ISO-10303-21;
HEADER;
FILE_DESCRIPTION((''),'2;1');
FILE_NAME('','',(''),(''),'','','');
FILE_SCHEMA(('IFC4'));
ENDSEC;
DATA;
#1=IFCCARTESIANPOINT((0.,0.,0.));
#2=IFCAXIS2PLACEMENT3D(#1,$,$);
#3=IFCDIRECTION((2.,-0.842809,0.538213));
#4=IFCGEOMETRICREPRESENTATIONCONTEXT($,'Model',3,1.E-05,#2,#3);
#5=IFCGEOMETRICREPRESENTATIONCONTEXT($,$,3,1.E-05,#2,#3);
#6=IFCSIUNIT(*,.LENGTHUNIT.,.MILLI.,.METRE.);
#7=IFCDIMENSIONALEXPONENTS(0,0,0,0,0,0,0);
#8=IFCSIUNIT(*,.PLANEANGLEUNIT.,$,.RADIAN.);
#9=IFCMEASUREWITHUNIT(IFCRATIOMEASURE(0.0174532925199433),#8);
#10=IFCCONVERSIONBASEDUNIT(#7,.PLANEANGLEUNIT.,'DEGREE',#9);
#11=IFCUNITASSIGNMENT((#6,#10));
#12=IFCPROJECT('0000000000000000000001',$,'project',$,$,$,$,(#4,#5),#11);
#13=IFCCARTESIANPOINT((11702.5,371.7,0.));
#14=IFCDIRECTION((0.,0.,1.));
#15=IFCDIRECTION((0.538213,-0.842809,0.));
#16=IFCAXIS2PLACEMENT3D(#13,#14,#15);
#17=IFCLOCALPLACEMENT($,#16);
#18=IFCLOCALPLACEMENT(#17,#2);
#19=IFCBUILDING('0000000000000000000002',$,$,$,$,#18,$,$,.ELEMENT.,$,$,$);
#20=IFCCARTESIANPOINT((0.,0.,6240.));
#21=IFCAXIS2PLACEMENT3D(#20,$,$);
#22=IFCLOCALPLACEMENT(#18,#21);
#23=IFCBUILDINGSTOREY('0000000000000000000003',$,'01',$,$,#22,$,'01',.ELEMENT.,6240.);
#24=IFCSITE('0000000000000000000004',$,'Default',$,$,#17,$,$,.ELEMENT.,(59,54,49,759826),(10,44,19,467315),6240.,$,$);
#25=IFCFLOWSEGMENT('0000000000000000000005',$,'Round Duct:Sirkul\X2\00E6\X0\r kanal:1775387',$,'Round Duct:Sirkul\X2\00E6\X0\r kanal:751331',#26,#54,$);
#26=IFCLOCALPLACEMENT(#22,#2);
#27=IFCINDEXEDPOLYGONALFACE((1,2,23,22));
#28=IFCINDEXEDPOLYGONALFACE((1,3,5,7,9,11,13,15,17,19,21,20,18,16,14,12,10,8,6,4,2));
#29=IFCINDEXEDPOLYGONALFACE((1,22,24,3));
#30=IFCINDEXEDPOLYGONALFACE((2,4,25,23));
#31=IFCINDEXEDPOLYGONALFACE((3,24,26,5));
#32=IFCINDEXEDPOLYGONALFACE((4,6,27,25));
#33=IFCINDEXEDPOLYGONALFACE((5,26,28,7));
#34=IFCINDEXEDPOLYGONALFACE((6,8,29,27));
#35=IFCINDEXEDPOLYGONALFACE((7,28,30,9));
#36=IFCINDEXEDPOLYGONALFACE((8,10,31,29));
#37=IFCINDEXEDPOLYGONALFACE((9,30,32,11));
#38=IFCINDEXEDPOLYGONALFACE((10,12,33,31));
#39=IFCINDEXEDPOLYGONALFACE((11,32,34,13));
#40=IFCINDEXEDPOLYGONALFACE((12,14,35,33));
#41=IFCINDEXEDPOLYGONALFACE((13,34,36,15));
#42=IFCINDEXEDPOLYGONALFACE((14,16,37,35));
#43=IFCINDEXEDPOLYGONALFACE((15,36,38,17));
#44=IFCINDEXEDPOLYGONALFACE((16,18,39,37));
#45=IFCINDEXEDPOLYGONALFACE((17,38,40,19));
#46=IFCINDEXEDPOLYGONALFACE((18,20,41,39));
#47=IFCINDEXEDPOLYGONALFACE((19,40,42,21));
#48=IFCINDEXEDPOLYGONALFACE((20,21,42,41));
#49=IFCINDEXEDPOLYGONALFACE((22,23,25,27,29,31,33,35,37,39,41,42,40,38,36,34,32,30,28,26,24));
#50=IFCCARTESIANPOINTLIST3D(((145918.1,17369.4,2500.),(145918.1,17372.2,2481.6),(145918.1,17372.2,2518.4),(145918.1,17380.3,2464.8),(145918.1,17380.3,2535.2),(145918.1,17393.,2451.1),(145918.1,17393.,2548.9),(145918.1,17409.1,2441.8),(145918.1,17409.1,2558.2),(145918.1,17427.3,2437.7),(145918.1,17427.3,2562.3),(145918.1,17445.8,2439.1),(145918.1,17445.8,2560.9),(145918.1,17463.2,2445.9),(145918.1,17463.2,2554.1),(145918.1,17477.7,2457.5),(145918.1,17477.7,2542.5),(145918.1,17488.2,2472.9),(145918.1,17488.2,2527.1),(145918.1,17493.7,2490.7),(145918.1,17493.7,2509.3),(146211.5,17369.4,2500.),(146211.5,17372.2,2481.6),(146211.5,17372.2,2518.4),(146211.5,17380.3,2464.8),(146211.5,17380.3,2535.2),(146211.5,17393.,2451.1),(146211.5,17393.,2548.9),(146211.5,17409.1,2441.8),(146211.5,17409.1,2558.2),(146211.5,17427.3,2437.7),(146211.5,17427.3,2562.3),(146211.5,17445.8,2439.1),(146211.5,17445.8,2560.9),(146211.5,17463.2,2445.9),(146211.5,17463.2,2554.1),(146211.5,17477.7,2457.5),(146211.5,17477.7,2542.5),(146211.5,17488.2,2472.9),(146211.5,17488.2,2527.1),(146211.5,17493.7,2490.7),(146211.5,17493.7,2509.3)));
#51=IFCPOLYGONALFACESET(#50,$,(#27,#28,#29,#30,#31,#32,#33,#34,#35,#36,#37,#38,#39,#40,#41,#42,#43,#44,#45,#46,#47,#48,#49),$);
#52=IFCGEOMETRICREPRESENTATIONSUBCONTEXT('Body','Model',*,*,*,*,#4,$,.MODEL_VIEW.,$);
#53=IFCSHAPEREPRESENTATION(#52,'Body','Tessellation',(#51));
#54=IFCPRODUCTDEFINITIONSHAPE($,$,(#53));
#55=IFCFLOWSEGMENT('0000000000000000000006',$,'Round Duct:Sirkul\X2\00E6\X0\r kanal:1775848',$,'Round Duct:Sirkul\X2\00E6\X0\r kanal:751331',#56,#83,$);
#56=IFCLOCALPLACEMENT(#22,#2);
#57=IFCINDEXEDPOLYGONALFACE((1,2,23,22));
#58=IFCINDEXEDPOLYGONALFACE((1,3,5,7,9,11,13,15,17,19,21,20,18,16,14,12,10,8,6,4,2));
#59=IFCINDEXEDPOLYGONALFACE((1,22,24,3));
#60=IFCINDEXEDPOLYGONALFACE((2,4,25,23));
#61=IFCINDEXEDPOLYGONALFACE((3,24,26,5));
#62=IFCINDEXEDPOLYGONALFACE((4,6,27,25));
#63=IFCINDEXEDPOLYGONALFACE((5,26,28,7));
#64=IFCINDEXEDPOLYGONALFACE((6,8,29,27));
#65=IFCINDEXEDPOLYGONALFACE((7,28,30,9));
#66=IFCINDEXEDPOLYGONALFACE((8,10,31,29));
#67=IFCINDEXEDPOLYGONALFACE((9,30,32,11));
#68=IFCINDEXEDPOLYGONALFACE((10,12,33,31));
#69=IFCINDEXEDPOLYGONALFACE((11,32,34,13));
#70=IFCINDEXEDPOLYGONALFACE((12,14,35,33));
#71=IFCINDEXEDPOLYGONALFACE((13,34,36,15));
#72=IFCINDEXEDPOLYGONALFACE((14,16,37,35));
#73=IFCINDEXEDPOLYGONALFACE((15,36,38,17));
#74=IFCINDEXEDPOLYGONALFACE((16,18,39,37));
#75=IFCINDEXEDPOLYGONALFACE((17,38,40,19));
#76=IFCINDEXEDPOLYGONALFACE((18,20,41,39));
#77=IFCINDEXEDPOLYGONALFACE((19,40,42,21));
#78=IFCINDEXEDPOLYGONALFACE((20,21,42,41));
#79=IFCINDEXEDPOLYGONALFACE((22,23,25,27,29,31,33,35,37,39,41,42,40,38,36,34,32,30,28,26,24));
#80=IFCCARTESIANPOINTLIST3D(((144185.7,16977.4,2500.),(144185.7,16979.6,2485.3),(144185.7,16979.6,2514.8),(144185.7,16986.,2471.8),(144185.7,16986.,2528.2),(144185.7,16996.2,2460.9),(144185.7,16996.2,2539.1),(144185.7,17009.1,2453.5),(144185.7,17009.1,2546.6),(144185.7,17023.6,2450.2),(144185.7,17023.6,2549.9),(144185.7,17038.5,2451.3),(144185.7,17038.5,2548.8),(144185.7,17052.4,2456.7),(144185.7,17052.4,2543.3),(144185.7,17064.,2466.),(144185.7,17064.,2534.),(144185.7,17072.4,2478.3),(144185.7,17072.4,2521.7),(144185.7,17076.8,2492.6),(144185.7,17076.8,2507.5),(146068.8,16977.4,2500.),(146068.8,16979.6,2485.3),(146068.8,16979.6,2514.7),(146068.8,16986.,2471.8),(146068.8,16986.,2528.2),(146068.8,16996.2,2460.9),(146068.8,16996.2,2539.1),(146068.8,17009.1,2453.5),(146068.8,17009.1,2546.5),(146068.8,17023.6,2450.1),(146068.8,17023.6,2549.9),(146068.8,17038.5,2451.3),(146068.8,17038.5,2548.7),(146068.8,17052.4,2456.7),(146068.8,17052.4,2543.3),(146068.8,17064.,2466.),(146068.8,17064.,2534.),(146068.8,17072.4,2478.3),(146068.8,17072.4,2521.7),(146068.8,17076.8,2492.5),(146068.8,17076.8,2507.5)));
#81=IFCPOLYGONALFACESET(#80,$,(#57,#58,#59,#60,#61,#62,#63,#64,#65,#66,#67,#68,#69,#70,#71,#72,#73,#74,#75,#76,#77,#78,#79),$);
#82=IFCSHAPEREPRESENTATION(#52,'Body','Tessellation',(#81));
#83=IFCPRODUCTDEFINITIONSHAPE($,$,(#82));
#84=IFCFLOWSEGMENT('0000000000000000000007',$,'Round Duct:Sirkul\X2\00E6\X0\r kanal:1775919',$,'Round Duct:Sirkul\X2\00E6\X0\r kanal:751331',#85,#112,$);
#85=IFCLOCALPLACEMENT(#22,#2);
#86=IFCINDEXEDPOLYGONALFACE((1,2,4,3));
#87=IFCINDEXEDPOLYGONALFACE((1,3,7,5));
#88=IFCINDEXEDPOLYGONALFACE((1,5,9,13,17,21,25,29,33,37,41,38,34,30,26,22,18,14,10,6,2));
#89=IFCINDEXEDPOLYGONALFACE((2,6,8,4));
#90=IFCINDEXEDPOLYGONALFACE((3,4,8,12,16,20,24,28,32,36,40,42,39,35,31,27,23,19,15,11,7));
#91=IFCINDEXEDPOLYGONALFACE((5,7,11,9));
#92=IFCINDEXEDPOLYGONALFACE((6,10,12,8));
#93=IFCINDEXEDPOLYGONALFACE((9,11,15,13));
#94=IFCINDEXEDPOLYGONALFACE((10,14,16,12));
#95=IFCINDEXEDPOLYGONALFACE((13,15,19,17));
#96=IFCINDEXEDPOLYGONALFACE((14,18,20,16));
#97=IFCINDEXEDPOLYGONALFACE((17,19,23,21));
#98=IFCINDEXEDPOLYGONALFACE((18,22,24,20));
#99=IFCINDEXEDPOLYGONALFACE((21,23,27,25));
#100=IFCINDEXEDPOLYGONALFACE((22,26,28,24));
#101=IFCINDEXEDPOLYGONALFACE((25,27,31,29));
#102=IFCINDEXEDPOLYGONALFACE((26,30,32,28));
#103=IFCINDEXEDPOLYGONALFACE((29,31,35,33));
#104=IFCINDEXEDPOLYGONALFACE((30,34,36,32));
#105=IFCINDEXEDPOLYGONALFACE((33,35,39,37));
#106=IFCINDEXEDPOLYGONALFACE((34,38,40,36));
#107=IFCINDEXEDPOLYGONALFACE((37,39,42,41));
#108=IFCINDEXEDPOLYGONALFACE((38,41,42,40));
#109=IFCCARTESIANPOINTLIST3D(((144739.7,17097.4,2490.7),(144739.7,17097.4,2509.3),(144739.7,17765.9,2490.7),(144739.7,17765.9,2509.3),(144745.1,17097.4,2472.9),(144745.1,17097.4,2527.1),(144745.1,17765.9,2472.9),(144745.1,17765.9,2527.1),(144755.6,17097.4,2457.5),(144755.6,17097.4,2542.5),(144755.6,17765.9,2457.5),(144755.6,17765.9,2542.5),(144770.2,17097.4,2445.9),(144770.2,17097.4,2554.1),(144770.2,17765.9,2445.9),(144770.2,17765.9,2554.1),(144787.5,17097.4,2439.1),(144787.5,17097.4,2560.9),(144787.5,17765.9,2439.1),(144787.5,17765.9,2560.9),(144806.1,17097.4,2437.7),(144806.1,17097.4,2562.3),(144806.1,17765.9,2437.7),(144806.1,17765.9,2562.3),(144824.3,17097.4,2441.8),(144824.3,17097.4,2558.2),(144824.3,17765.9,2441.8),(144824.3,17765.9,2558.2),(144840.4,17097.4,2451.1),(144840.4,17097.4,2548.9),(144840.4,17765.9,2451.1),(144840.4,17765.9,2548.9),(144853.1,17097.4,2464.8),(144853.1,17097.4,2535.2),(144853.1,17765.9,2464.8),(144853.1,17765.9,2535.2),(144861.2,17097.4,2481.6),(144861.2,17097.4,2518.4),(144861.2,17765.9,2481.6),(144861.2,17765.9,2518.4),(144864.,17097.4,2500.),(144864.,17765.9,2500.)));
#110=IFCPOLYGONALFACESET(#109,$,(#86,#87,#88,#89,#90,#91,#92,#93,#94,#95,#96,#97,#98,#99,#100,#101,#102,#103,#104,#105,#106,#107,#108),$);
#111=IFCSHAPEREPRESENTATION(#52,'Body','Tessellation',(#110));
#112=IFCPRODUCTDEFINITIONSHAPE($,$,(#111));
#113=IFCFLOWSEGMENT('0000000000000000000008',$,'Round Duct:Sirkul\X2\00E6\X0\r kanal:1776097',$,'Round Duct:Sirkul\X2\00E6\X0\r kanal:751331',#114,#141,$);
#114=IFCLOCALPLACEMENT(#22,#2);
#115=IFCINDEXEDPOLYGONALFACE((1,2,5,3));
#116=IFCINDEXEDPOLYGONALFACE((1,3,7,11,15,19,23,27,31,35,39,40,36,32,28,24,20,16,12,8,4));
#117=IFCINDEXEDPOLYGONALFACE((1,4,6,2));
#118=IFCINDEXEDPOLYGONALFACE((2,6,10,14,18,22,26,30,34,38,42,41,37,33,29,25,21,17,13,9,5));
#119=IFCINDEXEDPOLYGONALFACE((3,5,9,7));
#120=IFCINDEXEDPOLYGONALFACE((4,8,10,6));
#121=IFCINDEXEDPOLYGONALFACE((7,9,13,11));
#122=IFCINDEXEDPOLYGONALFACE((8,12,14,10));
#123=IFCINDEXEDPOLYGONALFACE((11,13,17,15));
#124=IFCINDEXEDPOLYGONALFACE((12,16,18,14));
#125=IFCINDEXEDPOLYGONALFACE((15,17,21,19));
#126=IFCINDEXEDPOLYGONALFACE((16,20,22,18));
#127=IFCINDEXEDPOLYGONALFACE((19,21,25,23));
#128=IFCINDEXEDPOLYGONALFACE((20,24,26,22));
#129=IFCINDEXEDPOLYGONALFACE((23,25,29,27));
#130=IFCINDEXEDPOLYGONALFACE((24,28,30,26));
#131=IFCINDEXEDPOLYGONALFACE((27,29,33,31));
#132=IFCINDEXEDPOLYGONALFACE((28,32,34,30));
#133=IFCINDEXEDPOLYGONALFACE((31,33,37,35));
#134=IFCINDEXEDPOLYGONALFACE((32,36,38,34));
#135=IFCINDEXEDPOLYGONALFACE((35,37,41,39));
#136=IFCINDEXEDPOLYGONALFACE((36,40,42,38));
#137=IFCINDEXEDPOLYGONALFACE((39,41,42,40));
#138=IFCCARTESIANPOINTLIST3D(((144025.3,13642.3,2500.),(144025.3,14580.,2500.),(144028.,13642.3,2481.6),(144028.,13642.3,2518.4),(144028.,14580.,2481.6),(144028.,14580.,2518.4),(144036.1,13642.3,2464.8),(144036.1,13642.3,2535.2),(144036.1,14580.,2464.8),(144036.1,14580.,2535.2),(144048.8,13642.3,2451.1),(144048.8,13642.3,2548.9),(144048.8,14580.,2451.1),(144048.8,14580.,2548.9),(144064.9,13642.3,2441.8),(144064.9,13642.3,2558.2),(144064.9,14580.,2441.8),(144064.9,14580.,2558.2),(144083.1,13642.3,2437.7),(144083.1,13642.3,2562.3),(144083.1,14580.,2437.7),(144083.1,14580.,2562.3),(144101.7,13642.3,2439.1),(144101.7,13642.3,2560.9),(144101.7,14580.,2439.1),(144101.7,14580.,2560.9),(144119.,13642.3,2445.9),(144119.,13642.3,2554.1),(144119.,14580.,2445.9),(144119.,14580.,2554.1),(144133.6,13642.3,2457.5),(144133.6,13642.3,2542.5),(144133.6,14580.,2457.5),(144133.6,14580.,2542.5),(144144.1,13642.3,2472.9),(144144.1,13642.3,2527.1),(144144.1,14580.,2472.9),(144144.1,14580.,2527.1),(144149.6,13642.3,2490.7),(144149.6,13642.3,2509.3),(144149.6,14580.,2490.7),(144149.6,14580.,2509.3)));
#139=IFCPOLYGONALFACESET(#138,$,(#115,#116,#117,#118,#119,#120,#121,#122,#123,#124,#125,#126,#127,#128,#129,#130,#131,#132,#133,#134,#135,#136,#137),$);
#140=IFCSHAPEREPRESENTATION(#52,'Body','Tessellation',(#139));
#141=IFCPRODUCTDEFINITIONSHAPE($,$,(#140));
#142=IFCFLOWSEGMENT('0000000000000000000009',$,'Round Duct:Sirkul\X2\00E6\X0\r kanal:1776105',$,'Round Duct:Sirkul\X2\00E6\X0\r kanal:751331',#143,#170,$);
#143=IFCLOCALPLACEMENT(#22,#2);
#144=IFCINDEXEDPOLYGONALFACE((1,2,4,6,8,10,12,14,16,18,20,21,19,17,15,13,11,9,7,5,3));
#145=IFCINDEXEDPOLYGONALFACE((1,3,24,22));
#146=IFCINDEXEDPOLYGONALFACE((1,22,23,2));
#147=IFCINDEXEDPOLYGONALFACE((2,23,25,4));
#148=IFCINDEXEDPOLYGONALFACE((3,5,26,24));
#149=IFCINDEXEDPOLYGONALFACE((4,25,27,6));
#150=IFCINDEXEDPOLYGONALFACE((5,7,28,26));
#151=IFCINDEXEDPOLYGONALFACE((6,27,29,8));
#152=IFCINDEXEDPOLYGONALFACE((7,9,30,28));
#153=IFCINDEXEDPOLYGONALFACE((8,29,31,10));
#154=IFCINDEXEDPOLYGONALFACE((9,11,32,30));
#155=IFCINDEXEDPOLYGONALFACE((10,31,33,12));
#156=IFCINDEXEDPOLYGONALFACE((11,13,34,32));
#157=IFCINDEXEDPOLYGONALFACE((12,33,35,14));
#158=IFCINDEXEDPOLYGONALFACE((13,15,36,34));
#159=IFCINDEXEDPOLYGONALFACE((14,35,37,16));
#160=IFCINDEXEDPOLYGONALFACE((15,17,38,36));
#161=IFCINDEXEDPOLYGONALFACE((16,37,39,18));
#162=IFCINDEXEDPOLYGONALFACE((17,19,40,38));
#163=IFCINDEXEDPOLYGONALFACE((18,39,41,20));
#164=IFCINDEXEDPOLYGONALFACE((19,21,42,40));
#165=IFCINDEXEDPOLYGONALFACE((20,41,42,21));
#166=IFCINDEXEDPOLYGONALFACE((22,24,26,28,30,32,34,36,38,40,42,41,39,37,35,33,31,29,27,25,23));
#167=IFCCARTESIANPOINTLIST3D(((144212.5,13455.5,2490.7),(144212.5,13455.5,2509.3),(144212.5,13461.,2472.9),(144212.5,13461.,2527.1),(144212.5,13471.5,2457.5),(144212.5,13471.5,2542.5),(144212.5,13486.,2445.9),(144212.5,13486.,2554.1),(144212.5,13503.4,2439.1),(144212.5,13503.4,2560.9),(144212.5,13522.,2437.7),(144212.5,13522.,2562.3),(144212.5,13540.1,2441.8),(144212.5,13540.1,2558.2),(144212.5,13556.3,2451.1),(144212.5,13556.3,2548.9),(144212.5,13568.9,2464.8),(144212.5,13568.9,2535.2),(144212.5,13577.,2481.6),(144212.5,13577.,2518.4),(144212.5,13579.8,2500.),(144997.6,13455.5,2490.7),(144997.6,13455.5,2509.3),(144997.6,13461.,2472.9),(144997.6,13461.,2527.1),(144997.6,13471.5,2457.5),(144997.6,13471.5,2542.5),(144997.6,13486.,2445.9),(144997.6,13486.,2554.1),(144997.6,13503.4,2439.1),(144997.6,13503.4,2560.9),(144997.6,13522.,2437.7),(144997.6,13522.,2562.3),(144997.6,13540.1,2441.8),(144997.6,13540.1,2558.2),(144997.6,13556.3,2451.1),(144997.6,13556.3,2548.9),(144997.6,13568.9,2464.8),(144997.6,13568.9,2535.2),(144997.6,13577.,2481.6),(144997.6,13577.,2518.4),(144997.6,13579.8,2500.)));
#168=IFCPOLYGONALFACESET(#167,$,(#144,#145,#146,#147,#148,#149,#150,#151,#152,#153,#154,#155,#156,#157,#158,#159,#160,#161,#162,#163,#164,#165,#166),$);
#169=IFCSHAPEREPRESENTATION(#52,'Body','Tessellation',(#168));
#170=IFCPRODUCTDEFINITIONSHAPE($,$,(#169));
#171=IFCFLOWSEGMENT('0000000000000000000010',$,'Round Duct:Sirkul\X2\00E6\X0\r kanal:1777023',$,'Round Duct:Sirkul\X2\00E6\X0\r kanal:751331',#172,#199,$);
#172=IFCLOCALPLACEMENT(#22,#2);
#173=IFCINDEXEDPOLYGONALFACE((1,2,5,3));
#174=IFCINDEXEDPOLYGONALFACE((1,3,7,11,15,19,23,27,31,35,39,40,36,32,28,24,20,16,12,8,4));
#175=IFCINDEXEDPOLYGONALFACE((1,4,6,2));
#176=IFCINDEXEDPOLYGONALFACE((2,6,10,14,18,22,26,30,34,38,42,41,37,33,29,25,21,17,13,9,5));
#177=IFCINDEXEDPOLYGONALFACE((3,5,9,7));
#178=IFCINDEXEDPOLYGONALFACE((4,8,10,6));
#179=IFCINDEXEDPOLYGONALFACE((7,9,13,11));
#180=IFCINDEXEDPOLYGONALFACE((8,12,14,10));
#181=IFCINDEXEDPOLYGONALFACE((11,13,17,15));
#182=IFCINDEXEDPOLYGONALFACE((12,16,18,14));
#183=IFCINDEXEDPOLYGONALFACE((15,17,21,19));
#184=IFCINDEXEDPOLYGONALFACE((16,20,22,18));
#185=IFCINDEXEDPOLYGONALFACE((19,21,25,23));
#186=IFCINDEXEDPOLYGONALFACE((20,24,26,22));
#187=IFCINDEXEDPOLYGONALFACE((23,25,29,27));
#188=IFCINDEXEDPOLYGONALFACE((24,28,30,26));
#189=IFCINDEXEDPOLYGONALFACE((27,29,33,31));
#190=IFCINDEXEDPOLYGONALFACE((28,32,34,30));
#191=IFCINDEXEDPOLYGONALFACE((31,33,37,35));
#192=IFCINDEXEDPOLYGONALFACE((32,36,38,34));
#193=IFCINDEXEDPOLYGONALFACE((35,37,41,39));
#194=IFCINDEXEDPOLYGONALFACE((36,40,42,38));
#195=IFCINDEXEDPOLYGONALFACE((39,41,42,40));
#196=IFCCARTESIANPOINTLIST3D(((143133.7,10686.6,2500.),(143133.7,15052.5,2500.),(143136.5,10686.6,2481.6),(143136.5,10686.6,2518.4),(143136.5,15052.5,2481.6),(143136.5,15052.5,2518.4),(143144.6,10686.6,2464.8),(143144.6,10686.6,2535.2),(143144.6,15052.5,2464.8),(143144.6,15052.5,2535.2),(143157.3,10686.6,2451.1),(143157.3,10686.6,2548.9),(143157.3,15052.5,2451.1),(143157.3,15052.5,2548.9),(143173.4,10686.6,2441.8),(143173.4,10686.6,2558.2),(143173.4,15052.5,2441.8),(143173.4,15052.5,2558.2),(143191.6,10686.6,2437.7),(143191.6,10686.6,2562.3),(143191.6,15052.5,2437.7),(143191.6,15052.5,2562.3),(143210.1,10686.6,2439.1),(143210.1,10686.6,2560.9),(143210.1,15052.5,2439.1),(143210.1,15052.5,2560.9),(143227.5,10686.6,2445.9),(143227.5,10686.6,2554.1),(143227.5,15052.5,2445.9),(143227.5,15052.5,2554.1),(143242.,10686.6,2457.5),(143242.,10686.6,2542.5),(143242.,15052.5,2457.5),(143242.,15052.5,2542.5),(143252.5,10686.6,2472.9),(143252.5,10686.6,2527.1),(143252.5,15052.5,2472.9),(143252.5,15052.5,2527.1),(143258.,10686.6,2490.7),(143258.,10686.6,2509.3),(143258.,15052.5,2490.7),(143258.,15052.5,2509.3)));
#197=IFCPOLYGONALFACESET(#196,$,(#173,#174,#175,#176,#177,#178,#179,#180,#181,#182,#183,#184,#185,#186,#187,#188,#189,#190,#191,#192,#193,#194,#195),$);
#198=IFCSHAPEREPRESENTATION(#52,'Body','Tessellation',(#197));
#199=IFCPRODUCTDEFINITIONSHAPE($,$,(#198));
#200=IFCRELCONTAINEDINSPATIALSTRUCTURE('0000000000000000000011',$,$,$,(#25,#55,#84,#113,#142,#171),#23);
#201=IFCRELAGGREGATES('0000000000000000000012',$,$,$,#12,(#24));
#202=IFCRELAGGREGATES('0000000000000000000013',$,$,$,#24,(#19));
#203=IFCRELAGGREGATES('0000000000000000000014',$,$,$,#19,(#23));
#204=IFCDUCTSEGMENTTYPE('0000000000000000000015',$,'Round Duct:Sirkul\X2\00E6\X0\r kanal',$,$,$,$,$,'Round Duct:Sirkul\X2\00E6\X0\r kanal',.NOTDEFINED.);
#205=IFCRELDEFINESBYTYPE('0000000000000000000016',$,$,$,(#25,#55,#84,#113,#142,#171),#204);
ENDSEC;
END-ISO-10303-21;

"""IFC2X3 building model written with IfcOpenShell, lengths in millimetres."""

from ifc_helpers import new_model, entity, si_unit, converted_unit, direction, frame, frame_2d, origin, origin_2d_with_axis, place, context, subcontext, project, spatial, circle, extrude, type_object, element, save


model = new_model("IFC2X3")

# Units and contexts
model_context = context("Model", 3, precision=1e-05, world=origin(), true_north=direction((2.0, -0.842809, 0.538213)))
context_of_model = context(None, 3, precision=1e-05, world=origin(), true_north=direction((2.0, -0.842809, 0.538213)))
body_context = subcontext(model_context, "Body", "Model", "MODEL_VIEW")
ifc_project = project(units=[si_unit("LENGTHUNIT", "METRE", prefix="MILLI"), converted_unit("PLANEANGLEUNIT", "DEGREE", entity("IfcRatioMeasure", 0.0174532925199433), si_unit("PLANEANGLEUNIT", "RADIAN"), dimensions=[0, 0, 0, 0, 0, 0, 0])], contexts=[model_context, context_of_model])

# Site, building, storey
site_placement = place(None, frame((11702.5, 371.7, 0.0), z_axis=(0.0, 0.0, 1.0), x_axis=(0.538213, -0.842809, 0.0)))
site = spatial("IfcSite", under=ifc_project, at=site_placement, Name="Default", CompositionType="ELEMENT", RefLatitude=(59, 54, 49, 759826), RefLongitude=(10, 44, 19, 467315), RefElevation=6240.0)
building_placement = place(site_placement, origin())
building = spatial("IfcBuilding", under=site, at=building_placement, CompositionType="ELEMENT")
storey_placement = place(building_placement, frame((0.0, 0.0, 6240.0)))
storey = spatial("IfcBuildingStorey", under=building, at=storey_placement, Name="01", LongName="01", CompositionType="ELEMENT", Elevation=6240.0)

# Flow segments
duct_segment_type_1 = type_object("IfcDuctSegmentType", Name="Round Duct:Sirkulær kanal", ElementType="Round Duct:Sirkulær kanal", PredefinedType="NOTDEFINED")
flow_segment_1_placement = place(storey_placement, origin())
element("IfcFlowSegment", 1, at=flow_segment_1_placement, inside=storey, type_object=duct_segment_type_1, Name="Round Duct:Sirkulær kanal:1775387", ObjectType="Round Duct:Sirkulær kanal:751331", context=body_context, shape_type="SweptSolid", body=[
    extrude(circle(Radius=62.5, at=frame_2d((0.0, 0.0), x_axis=(1.0, 0.0))), frame((145918.1, 17431.9, 2500.0), z_axis=(1.0, 0.0, 0.0), x_axis=(0.0, -1.0, 0.0)), (0.0, 0.0, 1.0), 293.4),
])
flow_segment_2_placement = place(storey_placement, origin())
element("IfcFlowSegment", 2, at=flow_segment_2_placement, inside=storey, type_object=duct_segment_type_1, Name="Round Duct:Sirkulær kanal:1775848", ObjectType="Round Duct:Sirkulær kanal:751331", context=body_context, shape_type="SweptSolid", body=[
    extrude(circle(Radius=50.0, at=origin_2d_with_axis()), frame((144185.7, 17027.4, 2500.0), z_axis=(1.0, 0.0, -0.000007), x_axis=(0.0, -1.0, 0.0)), (0.0, 0.0, 1.0), 1883.1),
])
flow_segment_3_placement = place(storey_placement, origin())
element("IfcFlowSegment", 3, at=flow_segment_3_placement, inside=storey, type_object=duct_segment_type_1, Name="Round Duct:Sirkulær kanal:1775919", ObjectType="Round Duct:Sirkulær kanal:751331", context=body_context, shape_type="SweptSolid", body=[
    extrude(circle(Radius=62.5, at=frame_2d((0.0, 0.0), x_axis=(1.0, 0.0))), frame((144801.5, 17097.4, 2500.0), z_axis=(0.0, 1.0, 0.0), x_axis=(1.0, 0.0, 0.0)), (0.0, 0.0, 1.0), 668.6),
])
flow_segment_4_placement = place(storey_placement, origin())
element("IfcFlowSegment", 4, at=flow_segment_4_placement, inside=storey, type_object=duct_segment_type_1, Name="Round Duct:Sirkulær kanal:1776097", ObjectType="Round Duct:Sirkulær kanal:751331", context=body_context, shape_type="SweptSolid", body=[
    extrude(circle(Radius=62.5, at=frame_2d((0.0, 0.0), x_axis=(1.0, 0.0))), frame((144087.8, 13642.3, 2500.0), z_axis=(0.0, 1.0, 0.0), x_axis=(-1.0, 0.0, 0.0)), (0.0, 0.0, 1.0), 937.7),
])
flow_segment_5_placement = place(storey_placement, origin())
element("IfcFlowSegment", 5, at=flow_segment_5_placement, inside=storey, type_object=duct_segment_type_1, Name="Round Duct:Sirkulær kanal:1776105", ObjectType="Round Duct:Sirkulær kanal:751331", context=body_context, shape_type="SweptSolid", body=[
    extrude(circle(Radius=62.5, at=frame_2d((0.0, 0.0), x_axis=(1.0, 0.0))), frame((144212.5, 13517.3, 2500.0), z_axis=(1.0, 0.0, 0.0), x_axis=(0.0, 1.0, 0.0)), (0.0, 0.0, 1.0), 785.1),
])
flow_segment_6_placement = place(storey_placement, origin())
element("IfcFlowSegment", 6, at=flow_segment_6_placement, inside=storey, type_object=duct_segment_type_1, Name="Round Duct:Sirkulær kanal:1777023", ObjectType="Round Duct:Sirkulær kanal:751331", context=body_context, shape_type="SweptSolid", body=[
    extrude(circle(Radius=62.5, at=frame_2d((0.0, 0.0), x_axis=(1.0, 0.0))), frame((143196.2, 10686.6, 2500.0), z_axis=(0.0, 1.0, 0.0), x_axis=(-1.0, 0.0, 0.0)), (0.0, 0.0, 1.0), 4365.9),
])

save(model, "model.ifc")
